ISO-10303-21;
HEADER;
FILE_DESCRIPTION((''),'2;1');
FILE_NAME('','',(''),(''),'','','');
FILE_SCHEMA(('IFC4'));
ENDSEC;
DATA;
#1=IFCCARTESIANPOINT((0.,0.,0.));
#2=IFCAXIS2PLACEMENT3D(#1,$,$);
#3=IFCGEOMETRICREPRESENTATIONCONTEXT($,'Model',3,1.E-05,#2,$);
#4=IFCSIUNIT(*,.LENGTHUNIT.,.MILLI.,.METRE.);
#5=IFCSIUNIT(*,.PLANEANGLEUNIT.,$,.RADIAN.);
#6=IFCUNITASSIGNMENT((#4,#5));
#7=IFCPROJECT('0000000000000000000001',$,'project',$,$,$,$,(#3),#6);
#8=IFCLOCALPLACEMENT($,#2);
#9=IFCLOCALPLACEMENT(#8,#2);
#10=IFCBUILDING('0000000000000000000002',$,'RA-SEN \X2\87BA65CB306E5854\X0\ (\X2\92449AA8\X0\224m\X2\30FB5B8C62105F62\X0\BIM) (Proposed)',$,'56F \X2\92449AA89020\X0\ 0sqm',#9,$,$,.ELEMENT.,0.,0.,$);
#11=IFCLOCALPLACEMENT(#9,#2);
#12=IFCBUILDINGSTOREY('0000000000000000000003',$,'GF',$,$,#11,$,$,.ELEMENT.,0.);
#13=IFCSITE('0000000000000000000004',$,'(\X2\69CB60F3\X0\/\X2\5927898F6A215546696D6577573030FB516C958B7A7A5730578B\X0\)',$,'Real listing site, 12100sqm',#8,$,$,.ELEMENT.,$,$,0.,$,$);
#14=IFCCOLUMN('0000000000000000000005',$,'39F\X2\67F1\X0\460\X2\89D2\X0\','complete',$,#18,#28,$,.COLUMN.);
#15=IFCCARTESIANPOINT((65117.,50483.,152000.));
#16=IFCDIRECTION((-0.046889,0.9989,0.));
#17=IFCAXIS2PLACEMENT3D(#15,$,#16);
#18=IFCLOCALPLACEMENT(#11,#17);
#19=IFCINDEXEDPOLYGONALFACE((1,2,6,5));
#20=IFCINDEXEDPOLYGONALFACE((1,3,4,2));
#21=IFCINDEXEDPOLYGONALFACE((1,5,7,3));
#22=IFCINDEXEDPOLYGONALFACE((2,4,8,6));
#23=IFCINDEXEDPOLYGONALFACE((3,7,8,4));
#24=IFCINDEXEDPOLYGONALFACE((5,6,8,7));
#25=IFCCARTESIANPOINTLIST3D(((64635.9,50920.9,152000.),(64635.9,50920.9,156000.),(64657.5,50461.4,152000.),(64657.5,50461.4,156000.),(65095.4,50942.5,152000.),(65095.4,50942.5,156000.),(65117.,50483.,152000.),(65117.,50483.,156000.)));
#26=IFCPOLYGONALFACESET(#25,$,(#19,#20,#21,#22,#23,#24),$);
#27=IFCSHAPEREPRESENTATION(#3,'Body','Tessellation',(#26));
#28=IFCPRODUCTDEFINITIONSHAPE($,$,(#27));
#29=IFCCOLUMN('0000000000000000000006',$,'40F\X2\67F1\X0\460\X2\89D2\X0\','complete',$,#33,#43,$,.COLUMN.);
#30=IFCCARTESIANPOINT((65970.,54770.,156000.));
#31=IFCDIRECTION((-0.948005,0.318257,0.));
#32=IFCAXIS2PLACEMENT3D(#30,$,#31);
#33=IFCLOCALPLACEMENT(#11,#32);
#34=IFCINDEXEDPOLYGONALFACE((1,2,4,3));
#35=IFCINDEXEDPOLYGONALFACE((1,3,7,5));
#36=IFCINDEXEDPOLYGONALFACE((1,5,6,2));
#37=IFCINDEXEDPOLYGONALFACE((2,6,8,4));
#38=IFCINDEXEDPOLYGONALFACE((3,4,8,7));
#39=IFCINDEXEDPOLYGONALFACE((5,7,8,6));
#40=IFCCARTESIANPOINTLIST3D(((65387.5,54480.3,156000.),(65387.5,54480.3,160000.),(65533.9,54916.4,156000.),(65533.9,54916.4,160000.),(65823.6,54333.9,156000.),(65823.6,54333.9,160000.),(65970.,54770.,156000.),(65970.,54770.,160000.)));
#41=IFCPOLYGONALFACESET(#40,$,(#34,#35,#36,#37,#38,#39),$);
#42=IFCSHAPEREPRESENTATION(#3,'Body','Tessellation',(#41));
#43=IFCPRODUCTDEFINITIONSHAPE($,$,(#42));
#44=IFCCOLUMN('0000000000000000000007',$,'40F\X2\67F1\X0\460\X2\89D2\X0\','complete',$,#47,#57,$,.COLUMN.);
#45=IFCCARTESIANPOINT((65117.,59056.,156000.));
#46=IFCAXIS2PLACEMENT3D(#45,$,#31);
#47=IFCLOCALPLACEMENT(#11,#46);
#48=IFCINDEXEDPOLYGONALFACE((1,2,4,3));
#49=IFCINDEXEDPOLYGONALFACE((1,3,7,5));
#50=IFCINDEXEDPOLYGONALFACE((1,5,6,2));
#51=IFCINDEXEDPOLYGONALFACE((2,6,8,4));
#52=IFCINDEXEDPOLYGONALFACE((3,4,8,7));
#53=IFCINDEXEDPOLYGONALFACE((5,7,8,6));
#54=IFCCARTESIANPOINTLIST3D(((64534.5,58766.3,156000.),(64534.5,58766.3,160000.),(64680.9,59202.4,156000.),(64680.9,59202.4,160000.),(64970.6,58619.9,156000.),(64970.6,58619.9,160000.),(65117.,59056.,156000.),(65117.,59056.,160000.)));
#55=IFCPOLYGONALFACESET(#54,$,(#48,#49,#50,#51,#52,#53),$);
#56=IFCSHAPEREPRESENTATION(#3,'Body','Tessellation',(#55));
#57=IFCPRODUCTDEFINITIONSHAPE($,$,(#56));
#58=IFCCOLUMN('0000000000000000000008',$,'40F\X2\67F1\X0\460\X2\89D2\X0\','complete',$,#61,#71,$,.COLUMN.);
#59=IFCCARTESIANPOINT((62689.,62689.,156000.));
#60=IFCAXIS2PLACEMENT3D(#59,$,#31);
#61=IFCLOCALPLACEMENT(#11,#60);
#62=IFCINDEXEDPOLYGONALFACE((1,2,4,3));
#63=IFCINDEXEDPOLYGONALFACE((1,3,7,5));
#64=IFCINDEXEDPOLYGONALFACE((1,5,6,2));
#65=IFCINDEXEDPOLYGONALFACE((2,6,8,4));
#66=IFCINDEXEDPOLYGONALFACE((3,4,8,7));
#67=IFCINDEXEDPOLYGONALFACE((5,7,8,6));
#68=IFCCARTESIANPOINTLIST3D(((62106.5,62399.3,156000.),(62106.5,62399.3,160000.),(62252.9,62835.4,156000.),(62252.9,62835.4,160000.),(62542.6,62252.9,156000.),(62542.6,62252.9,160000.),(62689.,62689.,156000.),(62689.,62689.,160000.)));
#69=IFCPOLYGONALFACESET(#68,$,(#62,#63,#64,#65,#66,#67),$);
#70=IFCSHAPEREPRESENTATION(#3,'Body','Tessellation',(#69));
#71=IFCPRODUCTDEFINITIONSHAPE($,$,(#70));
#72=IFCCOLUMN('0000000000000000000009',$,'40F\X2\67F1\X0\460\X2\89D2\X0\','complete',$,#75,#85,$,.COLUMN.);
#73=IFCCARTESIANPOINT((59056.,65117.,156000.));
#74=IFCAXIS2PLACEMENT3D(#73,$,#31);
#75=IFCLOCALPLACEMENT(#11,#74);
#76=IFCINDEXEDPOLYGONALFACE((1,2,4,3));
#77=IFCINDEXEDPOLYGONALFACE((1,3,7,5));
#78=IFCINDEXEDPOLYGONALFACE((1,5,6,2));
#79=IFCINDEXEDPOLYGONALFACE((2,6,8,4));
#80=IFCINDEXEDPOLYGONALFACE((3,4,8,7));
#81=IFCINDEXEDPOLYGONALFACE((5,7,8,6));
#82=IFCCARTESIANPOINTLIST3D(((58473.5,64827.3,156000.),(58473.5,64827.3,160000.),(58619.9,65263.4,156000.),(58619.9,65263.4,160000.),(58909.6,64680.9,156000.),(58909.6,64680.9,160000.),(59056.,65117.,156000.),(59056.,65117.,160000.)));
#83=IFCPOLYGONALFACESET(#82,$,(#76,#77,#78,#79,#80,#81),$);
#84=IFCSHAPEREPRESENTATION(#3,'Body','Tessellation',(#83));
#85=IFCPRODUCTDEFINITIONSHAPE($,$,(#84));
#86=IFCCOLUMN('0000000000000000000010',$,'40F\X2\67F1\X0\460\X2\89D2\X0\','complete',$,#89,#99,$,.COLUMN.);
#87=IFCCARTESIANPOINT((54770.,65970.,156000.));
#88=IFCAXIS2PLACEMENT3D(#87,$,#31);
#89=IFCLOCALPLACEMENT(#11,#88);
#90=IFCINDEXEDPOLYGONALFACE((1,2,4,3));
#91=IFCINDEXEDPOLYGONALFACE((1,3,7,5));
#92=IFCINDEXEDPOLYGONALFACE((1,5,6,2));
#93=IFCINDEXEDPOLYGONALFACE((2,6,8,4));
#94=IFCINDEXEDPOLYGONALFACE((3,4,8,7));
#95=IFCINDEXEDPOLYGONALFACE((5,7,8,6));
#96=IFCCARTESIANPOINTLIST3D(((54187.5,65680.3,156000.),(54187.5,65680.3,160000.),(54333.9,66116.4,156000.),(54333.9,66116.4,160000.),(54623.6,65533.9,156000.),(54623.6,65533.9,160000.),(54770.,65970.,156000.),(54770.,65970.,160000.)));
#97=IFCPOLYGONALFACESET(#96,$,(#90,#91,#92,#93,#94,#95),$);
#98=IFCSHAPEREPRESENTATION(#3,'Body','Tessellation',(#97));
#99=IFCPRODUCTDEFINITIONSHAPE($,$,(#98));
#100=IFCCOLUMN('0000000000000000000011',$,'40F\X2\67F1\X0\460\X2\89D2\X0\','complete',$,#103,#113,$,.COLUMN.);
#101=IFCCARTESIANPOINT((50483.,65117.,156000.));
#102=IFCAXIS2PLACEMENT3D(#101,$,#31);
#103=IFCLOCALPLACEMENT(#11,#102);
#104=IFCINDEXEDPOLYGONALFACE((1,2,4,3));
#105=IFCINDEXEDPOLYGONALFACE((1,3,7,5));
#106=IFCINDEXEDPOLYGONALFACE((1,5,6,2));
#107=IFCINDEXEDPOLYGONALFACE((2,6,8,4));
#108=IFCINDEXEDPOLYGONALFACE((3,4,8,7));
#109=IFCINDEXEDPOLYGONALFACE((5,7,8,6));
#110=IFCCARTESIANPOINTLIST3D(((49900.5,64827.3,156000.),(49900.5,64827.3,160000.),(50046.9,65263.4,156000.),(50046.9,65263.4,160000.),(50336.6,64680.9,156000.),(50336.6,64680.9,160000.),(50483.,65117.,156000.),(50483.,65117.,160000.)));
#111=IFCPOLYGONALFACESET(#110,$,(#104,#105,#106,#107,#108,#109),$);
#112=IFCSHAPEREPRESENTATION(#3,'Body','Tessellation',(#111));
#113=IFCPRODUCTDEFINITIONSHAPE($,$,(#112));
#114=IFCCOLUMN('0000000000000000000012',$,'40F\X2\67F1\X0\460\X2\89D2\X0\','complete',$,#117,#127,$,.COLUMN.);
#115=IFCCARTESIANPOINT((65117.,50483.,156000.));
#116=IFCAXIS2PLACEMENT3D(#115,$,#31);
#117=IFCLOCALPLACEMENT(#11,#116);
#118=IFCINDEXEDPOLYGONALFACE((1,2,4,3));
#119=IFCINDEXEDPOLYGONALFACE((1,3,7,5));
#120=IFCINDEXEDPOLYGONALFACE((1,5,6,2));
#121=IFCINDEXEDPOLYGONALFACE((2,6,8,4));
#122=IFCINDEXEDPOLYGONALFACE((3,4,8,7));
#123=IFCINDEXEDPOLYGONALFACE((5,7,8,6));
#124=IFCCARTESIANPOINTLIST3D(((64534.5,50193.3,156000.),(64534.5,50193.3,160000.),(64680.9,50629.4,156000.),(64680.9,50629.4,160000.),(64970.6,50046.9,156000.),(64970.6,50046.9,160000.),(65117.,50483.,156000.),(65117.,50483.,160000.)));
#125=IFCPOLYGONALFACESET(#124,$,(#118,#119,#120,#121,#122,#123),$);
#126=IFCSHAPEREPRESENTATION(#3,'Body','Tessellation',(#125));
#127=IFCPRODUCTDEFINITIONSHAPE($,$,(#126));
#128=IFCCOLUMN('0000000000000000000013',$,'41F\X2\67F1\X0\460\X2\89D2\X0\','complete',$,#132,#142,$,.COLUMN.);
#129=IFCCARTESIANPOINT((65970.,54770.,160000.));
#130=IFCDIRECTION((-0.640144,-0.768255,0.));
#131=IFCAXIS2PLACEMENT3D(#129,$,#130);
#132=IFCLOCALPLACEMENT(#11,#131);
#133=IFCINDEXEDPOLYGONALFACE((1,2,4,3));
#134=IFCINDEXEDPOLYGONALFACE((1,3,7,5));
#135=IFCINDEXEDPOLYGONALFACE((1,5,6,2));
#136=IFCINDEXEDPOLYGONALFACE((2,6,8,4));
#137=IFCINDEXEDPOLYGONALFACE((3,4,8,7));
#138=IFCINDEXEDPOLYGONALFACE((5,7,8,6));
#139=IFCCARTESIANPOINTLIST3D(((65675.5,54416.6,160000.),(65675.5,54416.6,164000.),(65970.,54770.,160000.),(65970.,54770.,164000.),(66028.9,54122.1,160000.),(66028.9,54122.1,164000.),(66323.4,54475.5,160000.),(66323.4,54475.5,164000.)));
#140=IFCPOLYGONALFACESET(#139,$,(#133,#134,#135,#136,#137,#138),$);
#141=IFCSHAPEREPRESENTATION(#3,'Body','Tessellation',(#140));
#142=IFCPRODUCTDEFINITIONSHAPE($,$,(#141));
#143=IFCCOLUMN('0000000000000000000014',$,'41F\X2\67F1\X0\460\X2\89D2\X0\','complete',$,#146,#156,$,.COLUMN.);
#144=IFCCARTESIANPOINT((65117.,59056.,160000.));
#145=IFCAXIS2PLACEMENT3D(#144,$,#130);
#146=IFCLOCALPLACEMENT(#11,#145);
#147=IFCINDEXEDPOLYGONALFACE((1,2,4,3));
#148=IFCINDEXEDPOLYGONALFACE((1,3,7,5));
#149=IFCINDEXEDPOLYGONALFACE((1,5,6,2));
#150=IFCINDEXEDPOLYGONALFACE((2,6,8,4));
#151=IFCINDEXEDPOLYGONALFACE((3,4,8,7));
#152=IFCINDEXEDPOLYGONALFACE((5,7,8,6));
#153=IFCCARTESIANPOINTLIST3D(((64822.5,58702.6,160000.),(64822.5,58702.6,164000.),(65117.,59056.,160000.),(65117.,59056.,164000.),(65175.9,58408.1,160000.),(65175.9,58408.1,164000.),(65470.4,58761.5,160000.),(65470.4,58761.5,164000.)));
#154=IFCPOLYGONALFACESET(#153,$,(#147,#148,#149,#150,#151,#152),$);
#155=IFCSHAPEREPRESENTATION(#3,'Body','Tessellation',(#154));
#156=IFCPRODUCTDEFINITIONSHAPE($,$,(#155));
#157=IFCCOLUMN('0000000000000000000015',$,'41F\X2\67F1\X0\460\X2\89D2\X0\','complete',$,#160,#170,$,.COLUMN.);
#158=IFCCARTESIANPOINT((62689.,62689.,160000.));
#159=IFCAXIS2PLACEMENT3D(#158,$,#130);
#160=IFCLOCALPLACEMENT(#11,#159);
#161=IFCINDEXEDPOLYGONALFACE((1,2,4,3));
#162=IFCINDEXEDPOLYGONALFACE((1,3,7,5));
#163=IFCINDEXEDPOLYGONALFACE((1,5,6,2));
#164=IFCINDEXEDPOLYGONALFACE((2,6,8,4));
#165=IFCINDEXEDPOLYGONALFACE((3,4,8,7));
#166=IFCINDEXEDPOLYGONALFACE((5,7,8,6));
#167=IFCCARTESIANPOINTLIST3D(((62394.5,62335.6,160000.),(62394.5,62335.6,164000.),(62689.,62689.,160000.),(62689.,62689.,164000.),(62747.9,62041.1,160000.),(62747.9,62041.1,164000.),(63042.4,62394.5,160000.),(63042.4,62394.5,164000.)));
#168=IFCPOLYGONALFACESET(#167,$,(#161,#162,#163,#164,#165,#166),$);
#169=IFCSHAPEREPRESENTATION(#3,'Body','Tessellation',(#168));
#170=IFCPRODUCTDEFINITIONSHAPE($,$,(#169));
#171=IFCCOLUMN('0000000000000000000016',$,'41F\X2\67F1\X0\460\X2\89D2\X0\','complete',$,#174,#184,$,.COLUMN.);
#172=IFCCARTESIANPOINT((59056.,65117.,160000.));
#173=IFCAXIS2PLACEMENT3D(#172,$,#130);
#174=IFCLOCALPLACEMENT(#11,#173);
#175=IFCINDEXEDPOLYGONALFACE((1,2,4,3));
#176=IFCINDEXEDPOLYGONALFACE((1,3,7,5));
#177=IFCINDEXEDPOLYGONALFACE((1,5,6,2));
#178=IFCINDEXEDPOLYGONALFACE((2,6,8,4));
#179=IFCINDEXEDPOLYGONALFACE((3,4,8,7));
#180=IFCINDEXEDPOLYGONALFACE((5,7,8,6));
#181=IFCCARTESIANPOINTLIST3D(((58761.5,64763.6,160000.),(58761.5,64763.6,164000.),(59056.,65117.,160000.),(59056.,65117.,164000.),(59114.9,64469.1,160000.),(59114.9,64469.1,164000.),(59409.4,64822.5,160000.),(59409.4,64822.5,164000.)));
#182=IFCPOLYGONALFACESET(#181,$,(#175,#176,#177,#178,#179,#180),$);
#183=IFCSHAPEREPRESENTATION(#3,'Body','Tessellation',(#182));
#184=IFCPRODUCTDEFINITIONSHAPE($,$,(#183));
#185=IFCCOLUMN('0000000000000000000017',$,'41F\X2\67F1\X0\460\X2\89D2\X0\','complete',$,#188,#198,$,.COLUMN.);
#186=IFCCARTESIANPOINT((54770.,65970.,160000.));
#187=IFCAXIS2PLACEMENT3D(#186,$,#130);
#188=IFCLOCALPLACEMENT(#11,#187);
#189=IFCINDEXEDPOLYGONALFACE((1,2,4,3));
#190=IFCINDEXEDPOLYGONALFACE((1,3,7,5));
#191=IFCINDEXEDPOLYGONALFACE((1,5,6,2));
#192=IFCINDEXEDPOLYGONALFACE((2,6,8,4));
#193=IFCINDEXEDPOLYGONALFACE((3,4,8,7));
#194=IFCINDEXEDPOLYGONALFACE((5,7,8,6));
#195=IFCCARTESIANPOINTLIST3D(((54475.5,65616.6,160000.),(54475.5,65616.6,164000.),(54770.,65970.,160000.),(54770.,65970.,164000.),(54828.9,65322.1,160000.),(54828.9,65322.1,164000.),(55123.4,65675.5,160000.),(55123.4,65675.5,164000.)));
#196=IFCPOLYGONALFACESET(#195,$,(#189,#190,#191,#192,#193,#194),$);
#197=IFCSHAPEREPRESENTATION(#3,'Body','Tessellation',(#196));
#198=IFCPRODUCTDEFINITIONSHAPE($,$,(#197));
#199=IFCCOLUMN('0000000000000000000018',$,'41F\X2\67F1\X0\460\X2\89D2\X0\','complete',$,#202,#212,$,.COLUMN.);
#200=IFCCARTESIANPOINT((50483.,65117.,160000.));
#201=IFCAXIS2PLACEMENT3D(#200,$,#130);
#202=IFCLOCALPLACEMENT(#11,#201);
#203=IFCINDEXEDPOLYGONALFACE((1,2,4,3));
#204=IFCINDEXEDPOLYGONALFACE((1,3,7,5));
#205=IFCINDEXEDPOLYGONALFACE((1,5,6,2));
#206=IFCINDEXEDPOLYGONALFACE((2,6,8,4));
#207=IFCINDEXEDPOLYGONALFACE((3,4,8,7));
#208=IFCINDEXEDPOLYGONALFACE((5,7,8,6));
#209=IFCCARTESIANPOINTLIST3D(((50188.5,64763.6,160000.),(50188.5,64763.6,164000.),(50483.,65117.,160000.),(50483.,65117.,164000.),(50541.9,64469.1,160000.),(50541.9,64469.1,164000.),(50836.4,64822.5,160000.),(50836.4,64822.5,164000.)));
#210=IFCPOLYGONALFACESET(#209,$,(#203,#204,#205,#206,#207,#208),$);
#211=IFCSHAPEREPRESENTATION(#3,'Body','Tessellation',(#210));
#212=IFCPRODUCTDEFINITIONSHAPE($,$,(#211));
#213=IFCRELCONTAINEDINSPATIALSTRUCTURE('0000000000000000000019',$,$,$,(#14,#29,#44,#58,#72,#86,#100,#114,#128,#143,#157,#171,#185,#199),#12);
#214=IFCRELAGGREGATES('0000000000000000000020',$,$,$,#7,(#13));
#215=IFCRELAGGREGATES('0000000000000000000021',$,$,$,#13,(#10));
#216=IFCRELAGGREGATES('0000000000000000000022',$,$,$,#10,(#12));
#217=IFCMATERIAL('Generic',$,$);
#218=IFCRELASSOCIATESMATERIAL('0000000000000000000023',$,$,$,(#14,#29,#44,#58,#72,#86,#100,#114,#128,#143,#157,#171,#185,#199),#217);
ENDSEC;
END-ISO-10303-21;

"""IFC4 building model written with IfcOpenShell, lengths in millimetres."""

from ifc_helpers import new_model, si_unit, frame, frame_2d, origin, place, context, project, spatial, rectangle, extrude, material, element, save


model = new_model("IFC4")

# Units and contexts
model_context = context("Model", 3, precision=1e-05, world=origin())
ifc_project = project(units=[si_unit("LENGTHUNIT", "METRE", prefix="MILLI"), si_unit("PLANEANGLEUNIT", "RADIAN")], contexts=[model_context])

# Site, building, storey
site_placement = place(None, origin())
site = spatial("IfcSite", under=ifc_project, at=site_placement, Name="(構想/大規模商業敷地・公開空地型)", ObjectType="Real listing site, 12100sqm", CompositionType="ELEMENT", RefElevation=0.0)
building_placement = place(site_placement, origin())
building = spatial("IfcBuilding", under=site, at=building_placement, Name="RA-SEN 螺旋の塔 (鉄骨224m・完成形BIM) (Proposed)", ObjectType="56F 鉄骨造 0sqm", CompositionType="ELEMENT", ElevationOfRefHeight=0.0, ElevationOfTerrain=0.0)
storey_placement = place(building_placement, origin())
storey = spatial("IfcBuildingStorey", under=building, at=storey_placement, Name="GF", CompositionType="ELEMENT", Elevation=0.0)

# Columns
ifc_material = material(Name="Generic")
column_1_placement = place(storey_placement, frame((65117.0, 50483.0, 152000.0), x_axis=(-0.046889, 0.9989, 0.0)))
element("IfcColumn", 1, at=column_1_placement, inside=storey, material=ifc_material, Name="39F柱460角", Description="complete", PredefinedType="COLUMN", context=model_context, shape_type="SweptSolid", body=[
    extrude(rectangle(XDim=460.0, YDim=460.0, at=frame_2d((230.0, 230.0))), frame((65117.0, 50483.0, 152000.0), x_axis=(-0.046889, 0.9989, 0.0)), (0.0, 0.0, 1.0), 4000.0),
])
column_2_placement = place(storey_placement, frame((65970.0, 54770.0, 156000.0), x_axis=(-0.948005, 0.318257, 0.0)))
element("IfcColumn", 2, at=column_2_placement, inside=storey, material=ifc_material, Name="40F柱460角", Description="complete", PredefinedType="COLUMN", context=model_context, shape_type="SweptSolid", body=[
    extrude(rectangle(XDim=460.0, YDim=460.0, at=frame_2d((230.0, 230.0))), frame((65970.0, 54770.0, 156000.0), x_axis=(-0.948005, 0.318257, 0.0)), (0.0, 0.0, 1.0), 4000.0),
])
column_3_placement = place(storey_placement, frame((65117.0, 59056.0, 156000.0), x_axis=(-0.948005, 0.318257, 0.0)))
element("IfcColumn", 3, at=column_3_placement, inside=storey, material=ifc_material, Name="40F柱460角", Description="complete", PredefinedType="COLUMN", context=model_context, shape_type="SweptSolid", body=[
    extrude(rectangle(XDim=460.0, YDim=460.0, at=frame_2d((230.0, 230.0))), frame((65117.0, 59056.0, 156000.0), x_axis=(-0.948005, 0.318257, 0.0)), (0.0, 0.0, 1.0), 4000.0),
])
column_4_placement = place(storey_placement, frame((62689.0, 62689.0, 156000.0), x_axis=(-0.948005, 0.318257, 0.0)))
element("IfcColumn", 4, at=column_4_placement, inside=storey, material=ifc_material, Name="40F柱460角", Description="complete", PredefinedType="COLUMN", context=model_context, shape_type="SweptSolid", body=[
    extrude(rectangle(XDim=460.0, YDim=460.0, at=frame_2d((230.0, 230.0))), frame((62689.0, 62689.0, 156000.0), x_axis=(-0.948005, 0.318257, 0.0)), (0.0, 0.0, 1.0), 4000.0),
])
column_5_placement = place(storey_placement, frame((59056.0, 65117.0, 156000.0), x_axis=(-0.948005, 0.318257, 0.0)))
element("IfcColumn", 5, at=column_5_placement, inside=storey, material=ifc_material, Name="40F柱460角", Description="complete", PredefinedType="COLUMN", context=model_context, shape_type="SweptSolid", body=[
    extrude(rectangle(XDim=460.0, YDim=460.0, at=frame_2d((230.0, 230.0))), frame((59056.0, 65117.0, 156000.0), x_axis=(-0.948005, 0.318257, 0.0)), (0.0, 0.0, 1.0), 4000.0),
])
column_6_placement = place(storey_placement, frame((54770.0, 65970.0, 156000.0), x_axis=(-0.948005, 0.318257, 0.0)))
element("IfcColumn", 6, at=column_6_placement, inside=storey, material=ifc_material, Name="40F柱460角", Description="complete", PredefinedType="COLUMN", context=model_context, shape_type="SweptSolid", body=[
    extrude(rectangle(XDim=460.0, YDim=460.0, at=frame_2d((230.0, 230.0))), frame((54770.0, 65970.0, 156000.0), x_axis=(-0.948005, 0.318257, 0.0)), (0.0, 0.0, 1.0), 4000.0),
])
column_7_placement = place(storey_placement, frame((50483.0, 65117.0, 156000.0), x_axis=(-0.948005, 0.318257, 0.0)))
element("IfcColumn", 7, at=column_7_placement, inside=storey, material=ifc_material, Name="40F柱460角", Description="complete", PredefinedType="COLUMN", context=model_context, shape_type="SweptSolid", body=[
    extrude(rectangle(XDim=460.0, YDim=460.0, at=frame_2d((230.0, 230.0))), frame((50483.0, 65117.0, 156000.0), x_axis=(-0.948005, 0.318257, 0.0)), (0.0, 0.0, 1.0), 4000.0),
])
column_8_placement = place(storey_placement, frame((65117.0, 50483.0, 156000.0), x_axis=(-0.948005, 0.318257, 0.0)))
element("IfcColumn", 8, at=column_8_placement, inside=storey, material=ifc_material, Name="40F柱460角", Description="complete", PredefinedType="COLUMN", context=model_context, shape_type="SweptSolid", body=[
    extrude(rectangle(XDim=460.0, YDim=460.0, at=frame_2d((230.0, 230.0))), frame((65117.0, 50483.0, 156000.0), x_axis=(-0.948005, 0.318257, 0.0)), (0.0, 0.0, 1.0), 4000.0),
])
column_9_placement = place(storey_placement, frame((65970.0, 54770.0, 160000.0), x_axis=(-0.640144, -0.768255, 0.0)))
element("IfcColumn", 9, at=column_9_placement, inside=storey, material=ifc_material, Name="41F柱460角", Description="complete", PredefinedType="COLUMN", context=model_context, shape_type="SweptSolid", body=[
    extrude(rectangle(XDim=460.0, YDim=460.0, at=frame_2d((230.0, 230.0))), frame((65970.0, 54770.0, 160000.0), x_axis=(-0.640144, -0.768255, 0.0)), (0.0, 0.0, 1.0), 4000.0),
])
column_10_placement = place(storey_placement, frame((65117.0, 59056.0, 160000.0), x_axis=(-0.640144, -0.768255, 0.0)))
element("IfcColumn", 10, at=column_10_placement, inside=storey, material=ifc_material, Name="41F柱460角", Description="complete", PredefinedType="COLUMN", context=model_context, shape_type="SweptSolid", body=[
    extrude(rectangle(XDim=460.0, YDim=460.0, at=frame_2d((230.0, 230.0))), frame((65117.0, 59056.0, 160000.0), x_axis=(-0.640144, -0.768255, 0.0)), (0.0, 0.0, 1.0), 4000.0),
])
column_11_placement = place(storey_placement, frame((62689.0, 62689.0, 160000.0), x_axis=(-0.640144, -0.768255, 0.0)))
element("IfcColumn", 11, at=column_11_placement, inside=storey, material=ifc_material, Name="41F柱460角", Description="complete", PredefinedType="COLUMN", context=model_context, shape_type="SweptSolid", body=[
    extrude(rectangle(XDim=460.0, YDim=460.0, at=frame_2d((230.0, 230.0))), frame((62689.0, 62689.0, 160000.0), x_axis=(-0.640144, -0.768255, 0.0)), (0.0, 0.0, 1.0), 4000.0),
])
column_12_placement = place(storey_placement, frame((59056.0, 65117.0, 160000.0), x_axis=(-0.640144, -0.768255, 0.0)))
element("IfcColumn", 12, at=column_12_placement, inside=storey, material=ifc_material, Name="41F柱460角", Description="complete", PredefinedType="COLUMN", context=model_context, shape_type="SweptSolid", body=[
    extrude(rectangle(XDim=460.0, YDim=460.0, at=frame_2d((230.0, 230.0))), frame((59056.0, 65117.0, 160000.0), x_axis=(-0.640144, -0.768255, 0.0)), (0.0, 0.0, 1.0), 4000.0),
])
column_13_placement = place(storey_placement, frame((54770.0, 65970.0, 160000.0), x_axis=(-0.640144, -0.768255, 0.0)))
element("IfcColumn", 13, at=column_13_placement, inside=storey, material=ifc_material, Name="41F柱460角", Description="complete", PredefinedType="COLUMN", context=model_context, shape_type="SweptSolid", body=[
    extrude(rectangle(XDim=460.0, YDim=460.0, at=frame_2d((230.0, 230.0))), frame((54770.0, 65970.0, 160000.0), x_axis=(-0.640144, -0.768255, 0.0)), (0.0, 0.0, 1.0), 4000.0),
])
column_14_placement = place(storey_placement, frame((50483.0, 65117.0, 160000.0), x_axis=(-0.640144, -0.768255, 0.0)))
element("IfcColumn", 14, at=column_14_placement, inside=storey, material=ifc_material, Name="41F柱460角", Description="complete", PredefinedType="COLUMN", context=model_context, shape_type="SweptSolid", body=[
    extrude(rectangle(XDim=460.0, YDim=460.0, at=frame_2d((230.0, 230.0))), frame((50483.0, 65117.0, 160000.0), x_axis=(-0.640144, -0.768255, 0.0)), (0.0, 0.0, 1.0), 4000.0),
])

save(model, "model.ifc")
